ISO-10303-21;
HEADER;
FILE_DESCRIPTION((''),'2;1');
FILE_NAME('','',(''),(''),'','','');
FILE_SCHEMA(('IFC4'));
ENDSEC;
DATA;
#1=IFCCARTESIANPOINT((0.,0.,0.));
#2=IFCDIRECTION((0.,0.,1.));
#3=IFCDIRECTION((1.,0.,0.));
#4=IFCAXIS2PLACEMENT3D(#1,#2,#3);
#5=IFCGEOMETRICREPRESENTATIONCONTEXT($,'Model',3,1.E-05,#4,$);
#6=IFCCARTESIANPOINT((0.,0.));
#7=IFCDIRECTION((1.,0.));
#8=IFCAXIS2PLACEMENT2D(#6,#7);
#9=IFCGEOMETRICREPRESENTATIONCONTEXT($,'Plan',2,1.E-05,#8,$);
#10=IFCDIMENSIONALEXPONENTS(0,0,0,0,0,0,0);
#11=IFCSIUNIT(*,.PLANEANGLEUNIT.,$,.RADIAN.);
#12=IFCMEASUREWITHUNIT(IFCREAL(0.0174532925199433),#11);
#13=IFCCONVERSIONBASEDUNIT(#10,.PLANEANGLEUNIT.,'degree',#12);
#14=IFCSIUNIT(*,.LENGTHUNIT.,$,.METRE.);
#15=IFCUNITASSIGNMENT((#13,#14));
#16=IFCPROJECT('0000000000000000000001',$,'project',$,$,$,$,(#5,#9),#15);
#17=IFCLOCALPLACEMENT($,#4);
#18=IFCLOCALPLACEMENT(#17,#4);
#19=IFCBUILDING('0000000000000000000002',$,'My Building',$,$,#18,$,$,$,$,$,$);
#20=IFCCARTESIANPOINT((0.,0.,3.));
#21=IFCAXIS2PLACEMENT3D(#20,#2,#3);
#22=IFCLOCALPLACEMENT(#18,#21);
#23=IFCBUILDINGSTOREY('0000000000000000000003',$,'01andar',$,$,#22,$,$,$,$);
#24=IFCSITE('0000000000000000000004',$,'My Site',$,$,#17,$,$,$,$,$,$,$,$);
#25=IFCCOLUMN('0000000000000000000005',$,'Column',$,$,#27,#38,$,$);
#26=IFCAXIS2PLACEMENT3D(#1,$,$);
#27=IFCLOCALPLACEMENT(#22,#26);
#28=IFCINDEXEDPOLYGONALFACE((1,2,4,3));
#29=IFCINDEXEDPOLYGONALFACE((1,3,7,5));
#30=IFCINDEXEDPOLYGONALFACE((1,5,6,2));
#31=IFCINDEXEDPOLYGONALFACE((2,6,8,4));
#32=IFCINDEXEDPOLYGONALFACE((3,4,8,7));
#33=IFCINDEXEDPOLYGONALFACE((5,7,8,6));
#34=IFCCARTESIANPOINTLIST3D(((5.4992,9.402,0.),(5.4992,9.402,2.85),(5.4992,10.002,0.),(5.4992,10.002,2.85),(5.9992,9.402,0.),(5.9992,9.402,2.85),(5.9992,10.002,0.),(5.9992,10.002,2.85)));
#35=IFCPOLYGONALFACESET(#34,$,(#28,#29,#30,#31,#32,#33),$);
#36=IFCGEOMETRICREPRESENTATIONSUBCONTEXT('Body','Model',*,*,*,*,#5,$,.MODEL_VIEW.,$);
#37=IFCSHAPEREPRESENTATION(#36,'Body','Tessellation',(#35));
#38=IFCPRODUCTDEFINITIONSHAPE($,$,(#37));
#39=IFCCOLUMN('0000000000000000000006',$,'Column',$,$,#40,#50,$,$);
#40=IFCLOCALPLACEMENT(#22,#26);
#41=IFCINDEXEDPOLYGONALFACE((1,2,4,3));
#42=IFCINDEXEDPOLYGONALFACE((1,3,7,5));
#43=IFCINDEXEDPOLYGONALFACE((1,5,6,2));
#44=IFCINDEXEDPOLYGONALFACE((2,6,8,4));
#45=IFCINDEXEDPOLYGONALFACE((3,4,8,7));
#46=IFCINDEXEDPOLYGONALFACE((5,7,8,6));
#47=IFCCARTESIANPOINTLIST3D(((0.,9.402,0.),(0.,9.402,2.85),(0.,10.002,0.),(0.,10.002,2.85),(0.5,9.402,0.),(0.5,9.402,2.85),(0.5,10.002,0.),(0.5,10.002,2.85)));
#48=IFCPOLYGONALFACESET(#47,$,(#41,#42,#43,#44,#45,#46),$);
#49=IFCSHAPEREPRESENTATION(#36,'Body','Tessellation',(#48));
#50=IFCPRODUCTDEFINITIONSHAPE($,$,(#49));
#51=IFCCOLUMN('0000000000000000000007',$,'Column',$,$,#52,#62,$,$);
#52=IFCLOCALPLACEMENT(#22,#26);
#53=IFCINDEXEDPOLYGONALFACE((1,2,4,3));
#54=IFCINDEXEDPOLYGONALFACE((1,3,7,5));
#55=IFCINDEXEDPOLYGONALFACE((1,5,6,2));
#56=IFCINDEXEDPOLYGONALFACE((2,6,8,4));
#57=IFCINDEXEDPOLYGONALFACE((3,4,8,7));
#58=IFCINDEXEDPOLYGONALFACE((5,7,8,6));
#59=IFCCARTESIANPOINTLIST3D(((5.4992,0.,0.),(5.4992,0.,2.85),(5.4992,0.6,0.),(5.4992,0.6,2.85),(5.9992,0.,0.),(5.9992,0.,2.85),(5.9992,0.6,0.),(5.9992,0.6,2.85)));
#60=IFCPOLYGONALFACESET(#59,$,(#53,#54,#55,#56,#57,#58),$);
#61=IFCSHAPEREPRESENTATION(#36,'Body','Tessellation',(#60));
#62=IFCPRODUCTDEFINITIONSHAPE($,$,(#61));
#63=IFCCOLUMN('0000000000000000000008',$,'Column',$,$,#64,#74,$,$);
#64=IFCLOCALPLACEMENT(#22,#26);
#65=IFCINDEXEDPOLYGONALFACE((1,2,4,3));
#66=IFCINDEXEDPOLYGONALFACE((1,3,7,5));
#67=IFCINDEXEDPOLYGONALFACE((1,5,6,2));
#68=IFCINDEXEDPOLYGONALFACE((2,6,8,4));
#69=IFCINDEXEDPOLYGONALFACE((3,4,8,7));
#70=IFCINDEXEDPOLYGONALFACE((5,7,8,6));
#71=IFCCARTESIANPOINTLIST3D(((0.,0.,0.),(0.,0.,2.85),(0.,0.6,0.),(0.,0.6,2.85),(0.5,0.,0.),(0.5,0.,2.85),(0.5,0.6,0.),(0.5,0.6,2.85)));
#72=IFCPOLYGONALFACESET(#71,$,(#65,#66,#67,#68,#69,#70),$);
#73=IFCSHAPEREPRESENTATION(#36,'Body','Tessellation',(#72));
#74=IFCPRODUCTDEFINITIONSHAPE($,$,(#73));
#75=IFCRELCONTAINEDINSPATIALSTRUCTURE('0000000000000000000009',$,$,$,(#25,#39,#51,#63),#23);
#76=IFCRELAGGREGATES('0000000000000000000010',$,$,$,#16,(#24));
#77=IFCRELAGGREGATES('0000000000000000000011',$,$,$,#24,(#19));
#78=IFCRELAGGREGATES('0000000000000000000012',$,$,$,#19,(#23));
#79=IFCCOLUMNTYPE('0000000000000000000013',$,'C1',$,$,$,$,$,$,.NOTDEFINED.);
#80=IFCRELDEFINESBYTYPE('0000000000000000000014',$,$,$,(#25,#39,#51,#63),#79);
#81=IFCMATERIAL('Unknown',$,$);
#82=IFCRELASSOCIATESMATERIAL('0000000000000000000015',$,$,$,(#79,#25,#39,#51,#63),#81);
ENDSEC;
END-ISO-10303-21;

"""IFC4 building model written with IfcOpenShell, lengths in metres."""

from ifc_helpers import new_model, entity, si_unit, converted_unit, frame, origin_with_axes, origin_2d_with_axis, place, context, subcontext, project, spatial, rectangle, extrude, material, material_profile, profile_set, profile_usage, type_object, element, save


model = new_model("IFC4")

# Units and contexts
model_context = context("Model", 3, precision=1e-05, world=origin_with_axes())
plan_context = context("Plan", 2, precision=1e-05, world=origin_2d_with_axis())
body_context = subcontext(model_context, "Body", "Model", "MODEL_VIEW")
ifc_project = project(units=[converted_unit("PLANEANGLEUNIT", "degree", entity("IfcReal", 0.0174532925199433), si_unit("PLANEANGLEUNIT", "RADIAN"), dimensions=[0, 0, 0, 0, 0, 0, 0]), si_unit("LENGTHUNIT", "METRE")], contexts=[model_context, plan_context])

# Site, building, storey
site_placement = place(None, origin_with_axes())
site = spatial("IfcSite", under=ifc_project, at=site_placement, Name="My Site")
building_placement = place(site_placement, origin_with_axes())
building = spatial("IfcBuilding", under=site, at=building_placement, Name="My Building")
storey_placement = place(building_placement, frame((0.0, 0.0, 3.0), z_axis=(0.0, 0.0, 1.0), x_axis=(1.0, 0.0, 0.0)))
storey = spatial("IfcBuildingStorey", under=building, at=storey_placement, Name="01andar")

# Columns
ifc_material = material(Name="Unknown")
ifc_material_profile = material_profile(ifc_material, rectangle(XDim=0.5, YDim=0.6))
ifc_profile_set = profile_set([ifc_material_profile])
ifc_profile_usage_1 = profile_usage(ifc_profile_set, cardinal=5)
column_type = type_object("IfcColumnType", Name="C1", PredefinedType="NOTDEFINED", material=ifc_profile_set)
column_1_placement = place(storey_placement, frame((5.7492, 9.702, 0.0), z_axis=(0.0, 0.0, 1.0), x_axis=(1.0, 0.0, 0.0)))
element("IfcColumn", 1, at=column_1_placement, inside=storey, type_object=column_type, material=ifc_profile_usage_1, Name="Column", context=body_context, shape_type="SweptSolid", body=[
    extrude(rectangle(XDim=0.5, YDim=0.6), origin_with_axes(), (0.0, 0.0, 1.0), 2.85),
])
ifc_profile_usage_2 = profile_usage(ifc_profile_set, cardinal=5)
column_2_placement = place(storey_placement, frame((0.25, 9.702, 0.0), z_axis=(0.0, 0.0, 1.0), x_axis=(1.0, 0.0, 0.0)))
element("IfcColumn", 2, at=column_2_placement, inside=storey, type_object=column_type, material=ifc_profile_usage_2, Name="Column", context=body_context, shape_type="SweptSolid", body=[
    extrude(rectangle(XDim=0.5, YDim=0.6), origin_with_axes(), (0.0, 0.0, 1.0), 2.85),
])
ifc_profile_usage_3 = profile_usage(ifc_profile_set, cardinal=5)
column_3_placement = place(storey_placement, frame((5.7492, 0.3, 0.0), z_axis=(0.0, 0.0, 1.0), x_axis=(1.0, 0.0, 0.0)))
element("IfcColumn", 3, at=column_3_placement, inside=storey, type_object=column_type, material=ifc_profile_usage_3, Name="Column", context=body_context, shape_type="SweptSolid", body=[
    extrude(rectangle(XDim=0.5, YDim=0.6), origin_with_axes(), (0.0, 0.0, 1.0), 2.85),
])
ifc_profile_usage_4 = profile_usage(ifc_profile_set, cardinal=5)
column_4_placement = place(storey_placement, frame((0.25, 0.3, 0.0), z_axis=(0.0, 0.0, 1.0), x_axis=(1.0, 0.0, 0.0)))
element("IfcColumn", 4, at=column_4_placement, inside=storey, type_object=column_type, material=ifc_profile_usage_4, Name="Column", context=body_context, shape_type="SweptSolid", body=[
    extrude(rectangle(XDim=0.5, YDim=0.6), origin_with_axes(), (0.0, 0.0, 1.0), 2.85),
])

save(model, "model.ifc")
